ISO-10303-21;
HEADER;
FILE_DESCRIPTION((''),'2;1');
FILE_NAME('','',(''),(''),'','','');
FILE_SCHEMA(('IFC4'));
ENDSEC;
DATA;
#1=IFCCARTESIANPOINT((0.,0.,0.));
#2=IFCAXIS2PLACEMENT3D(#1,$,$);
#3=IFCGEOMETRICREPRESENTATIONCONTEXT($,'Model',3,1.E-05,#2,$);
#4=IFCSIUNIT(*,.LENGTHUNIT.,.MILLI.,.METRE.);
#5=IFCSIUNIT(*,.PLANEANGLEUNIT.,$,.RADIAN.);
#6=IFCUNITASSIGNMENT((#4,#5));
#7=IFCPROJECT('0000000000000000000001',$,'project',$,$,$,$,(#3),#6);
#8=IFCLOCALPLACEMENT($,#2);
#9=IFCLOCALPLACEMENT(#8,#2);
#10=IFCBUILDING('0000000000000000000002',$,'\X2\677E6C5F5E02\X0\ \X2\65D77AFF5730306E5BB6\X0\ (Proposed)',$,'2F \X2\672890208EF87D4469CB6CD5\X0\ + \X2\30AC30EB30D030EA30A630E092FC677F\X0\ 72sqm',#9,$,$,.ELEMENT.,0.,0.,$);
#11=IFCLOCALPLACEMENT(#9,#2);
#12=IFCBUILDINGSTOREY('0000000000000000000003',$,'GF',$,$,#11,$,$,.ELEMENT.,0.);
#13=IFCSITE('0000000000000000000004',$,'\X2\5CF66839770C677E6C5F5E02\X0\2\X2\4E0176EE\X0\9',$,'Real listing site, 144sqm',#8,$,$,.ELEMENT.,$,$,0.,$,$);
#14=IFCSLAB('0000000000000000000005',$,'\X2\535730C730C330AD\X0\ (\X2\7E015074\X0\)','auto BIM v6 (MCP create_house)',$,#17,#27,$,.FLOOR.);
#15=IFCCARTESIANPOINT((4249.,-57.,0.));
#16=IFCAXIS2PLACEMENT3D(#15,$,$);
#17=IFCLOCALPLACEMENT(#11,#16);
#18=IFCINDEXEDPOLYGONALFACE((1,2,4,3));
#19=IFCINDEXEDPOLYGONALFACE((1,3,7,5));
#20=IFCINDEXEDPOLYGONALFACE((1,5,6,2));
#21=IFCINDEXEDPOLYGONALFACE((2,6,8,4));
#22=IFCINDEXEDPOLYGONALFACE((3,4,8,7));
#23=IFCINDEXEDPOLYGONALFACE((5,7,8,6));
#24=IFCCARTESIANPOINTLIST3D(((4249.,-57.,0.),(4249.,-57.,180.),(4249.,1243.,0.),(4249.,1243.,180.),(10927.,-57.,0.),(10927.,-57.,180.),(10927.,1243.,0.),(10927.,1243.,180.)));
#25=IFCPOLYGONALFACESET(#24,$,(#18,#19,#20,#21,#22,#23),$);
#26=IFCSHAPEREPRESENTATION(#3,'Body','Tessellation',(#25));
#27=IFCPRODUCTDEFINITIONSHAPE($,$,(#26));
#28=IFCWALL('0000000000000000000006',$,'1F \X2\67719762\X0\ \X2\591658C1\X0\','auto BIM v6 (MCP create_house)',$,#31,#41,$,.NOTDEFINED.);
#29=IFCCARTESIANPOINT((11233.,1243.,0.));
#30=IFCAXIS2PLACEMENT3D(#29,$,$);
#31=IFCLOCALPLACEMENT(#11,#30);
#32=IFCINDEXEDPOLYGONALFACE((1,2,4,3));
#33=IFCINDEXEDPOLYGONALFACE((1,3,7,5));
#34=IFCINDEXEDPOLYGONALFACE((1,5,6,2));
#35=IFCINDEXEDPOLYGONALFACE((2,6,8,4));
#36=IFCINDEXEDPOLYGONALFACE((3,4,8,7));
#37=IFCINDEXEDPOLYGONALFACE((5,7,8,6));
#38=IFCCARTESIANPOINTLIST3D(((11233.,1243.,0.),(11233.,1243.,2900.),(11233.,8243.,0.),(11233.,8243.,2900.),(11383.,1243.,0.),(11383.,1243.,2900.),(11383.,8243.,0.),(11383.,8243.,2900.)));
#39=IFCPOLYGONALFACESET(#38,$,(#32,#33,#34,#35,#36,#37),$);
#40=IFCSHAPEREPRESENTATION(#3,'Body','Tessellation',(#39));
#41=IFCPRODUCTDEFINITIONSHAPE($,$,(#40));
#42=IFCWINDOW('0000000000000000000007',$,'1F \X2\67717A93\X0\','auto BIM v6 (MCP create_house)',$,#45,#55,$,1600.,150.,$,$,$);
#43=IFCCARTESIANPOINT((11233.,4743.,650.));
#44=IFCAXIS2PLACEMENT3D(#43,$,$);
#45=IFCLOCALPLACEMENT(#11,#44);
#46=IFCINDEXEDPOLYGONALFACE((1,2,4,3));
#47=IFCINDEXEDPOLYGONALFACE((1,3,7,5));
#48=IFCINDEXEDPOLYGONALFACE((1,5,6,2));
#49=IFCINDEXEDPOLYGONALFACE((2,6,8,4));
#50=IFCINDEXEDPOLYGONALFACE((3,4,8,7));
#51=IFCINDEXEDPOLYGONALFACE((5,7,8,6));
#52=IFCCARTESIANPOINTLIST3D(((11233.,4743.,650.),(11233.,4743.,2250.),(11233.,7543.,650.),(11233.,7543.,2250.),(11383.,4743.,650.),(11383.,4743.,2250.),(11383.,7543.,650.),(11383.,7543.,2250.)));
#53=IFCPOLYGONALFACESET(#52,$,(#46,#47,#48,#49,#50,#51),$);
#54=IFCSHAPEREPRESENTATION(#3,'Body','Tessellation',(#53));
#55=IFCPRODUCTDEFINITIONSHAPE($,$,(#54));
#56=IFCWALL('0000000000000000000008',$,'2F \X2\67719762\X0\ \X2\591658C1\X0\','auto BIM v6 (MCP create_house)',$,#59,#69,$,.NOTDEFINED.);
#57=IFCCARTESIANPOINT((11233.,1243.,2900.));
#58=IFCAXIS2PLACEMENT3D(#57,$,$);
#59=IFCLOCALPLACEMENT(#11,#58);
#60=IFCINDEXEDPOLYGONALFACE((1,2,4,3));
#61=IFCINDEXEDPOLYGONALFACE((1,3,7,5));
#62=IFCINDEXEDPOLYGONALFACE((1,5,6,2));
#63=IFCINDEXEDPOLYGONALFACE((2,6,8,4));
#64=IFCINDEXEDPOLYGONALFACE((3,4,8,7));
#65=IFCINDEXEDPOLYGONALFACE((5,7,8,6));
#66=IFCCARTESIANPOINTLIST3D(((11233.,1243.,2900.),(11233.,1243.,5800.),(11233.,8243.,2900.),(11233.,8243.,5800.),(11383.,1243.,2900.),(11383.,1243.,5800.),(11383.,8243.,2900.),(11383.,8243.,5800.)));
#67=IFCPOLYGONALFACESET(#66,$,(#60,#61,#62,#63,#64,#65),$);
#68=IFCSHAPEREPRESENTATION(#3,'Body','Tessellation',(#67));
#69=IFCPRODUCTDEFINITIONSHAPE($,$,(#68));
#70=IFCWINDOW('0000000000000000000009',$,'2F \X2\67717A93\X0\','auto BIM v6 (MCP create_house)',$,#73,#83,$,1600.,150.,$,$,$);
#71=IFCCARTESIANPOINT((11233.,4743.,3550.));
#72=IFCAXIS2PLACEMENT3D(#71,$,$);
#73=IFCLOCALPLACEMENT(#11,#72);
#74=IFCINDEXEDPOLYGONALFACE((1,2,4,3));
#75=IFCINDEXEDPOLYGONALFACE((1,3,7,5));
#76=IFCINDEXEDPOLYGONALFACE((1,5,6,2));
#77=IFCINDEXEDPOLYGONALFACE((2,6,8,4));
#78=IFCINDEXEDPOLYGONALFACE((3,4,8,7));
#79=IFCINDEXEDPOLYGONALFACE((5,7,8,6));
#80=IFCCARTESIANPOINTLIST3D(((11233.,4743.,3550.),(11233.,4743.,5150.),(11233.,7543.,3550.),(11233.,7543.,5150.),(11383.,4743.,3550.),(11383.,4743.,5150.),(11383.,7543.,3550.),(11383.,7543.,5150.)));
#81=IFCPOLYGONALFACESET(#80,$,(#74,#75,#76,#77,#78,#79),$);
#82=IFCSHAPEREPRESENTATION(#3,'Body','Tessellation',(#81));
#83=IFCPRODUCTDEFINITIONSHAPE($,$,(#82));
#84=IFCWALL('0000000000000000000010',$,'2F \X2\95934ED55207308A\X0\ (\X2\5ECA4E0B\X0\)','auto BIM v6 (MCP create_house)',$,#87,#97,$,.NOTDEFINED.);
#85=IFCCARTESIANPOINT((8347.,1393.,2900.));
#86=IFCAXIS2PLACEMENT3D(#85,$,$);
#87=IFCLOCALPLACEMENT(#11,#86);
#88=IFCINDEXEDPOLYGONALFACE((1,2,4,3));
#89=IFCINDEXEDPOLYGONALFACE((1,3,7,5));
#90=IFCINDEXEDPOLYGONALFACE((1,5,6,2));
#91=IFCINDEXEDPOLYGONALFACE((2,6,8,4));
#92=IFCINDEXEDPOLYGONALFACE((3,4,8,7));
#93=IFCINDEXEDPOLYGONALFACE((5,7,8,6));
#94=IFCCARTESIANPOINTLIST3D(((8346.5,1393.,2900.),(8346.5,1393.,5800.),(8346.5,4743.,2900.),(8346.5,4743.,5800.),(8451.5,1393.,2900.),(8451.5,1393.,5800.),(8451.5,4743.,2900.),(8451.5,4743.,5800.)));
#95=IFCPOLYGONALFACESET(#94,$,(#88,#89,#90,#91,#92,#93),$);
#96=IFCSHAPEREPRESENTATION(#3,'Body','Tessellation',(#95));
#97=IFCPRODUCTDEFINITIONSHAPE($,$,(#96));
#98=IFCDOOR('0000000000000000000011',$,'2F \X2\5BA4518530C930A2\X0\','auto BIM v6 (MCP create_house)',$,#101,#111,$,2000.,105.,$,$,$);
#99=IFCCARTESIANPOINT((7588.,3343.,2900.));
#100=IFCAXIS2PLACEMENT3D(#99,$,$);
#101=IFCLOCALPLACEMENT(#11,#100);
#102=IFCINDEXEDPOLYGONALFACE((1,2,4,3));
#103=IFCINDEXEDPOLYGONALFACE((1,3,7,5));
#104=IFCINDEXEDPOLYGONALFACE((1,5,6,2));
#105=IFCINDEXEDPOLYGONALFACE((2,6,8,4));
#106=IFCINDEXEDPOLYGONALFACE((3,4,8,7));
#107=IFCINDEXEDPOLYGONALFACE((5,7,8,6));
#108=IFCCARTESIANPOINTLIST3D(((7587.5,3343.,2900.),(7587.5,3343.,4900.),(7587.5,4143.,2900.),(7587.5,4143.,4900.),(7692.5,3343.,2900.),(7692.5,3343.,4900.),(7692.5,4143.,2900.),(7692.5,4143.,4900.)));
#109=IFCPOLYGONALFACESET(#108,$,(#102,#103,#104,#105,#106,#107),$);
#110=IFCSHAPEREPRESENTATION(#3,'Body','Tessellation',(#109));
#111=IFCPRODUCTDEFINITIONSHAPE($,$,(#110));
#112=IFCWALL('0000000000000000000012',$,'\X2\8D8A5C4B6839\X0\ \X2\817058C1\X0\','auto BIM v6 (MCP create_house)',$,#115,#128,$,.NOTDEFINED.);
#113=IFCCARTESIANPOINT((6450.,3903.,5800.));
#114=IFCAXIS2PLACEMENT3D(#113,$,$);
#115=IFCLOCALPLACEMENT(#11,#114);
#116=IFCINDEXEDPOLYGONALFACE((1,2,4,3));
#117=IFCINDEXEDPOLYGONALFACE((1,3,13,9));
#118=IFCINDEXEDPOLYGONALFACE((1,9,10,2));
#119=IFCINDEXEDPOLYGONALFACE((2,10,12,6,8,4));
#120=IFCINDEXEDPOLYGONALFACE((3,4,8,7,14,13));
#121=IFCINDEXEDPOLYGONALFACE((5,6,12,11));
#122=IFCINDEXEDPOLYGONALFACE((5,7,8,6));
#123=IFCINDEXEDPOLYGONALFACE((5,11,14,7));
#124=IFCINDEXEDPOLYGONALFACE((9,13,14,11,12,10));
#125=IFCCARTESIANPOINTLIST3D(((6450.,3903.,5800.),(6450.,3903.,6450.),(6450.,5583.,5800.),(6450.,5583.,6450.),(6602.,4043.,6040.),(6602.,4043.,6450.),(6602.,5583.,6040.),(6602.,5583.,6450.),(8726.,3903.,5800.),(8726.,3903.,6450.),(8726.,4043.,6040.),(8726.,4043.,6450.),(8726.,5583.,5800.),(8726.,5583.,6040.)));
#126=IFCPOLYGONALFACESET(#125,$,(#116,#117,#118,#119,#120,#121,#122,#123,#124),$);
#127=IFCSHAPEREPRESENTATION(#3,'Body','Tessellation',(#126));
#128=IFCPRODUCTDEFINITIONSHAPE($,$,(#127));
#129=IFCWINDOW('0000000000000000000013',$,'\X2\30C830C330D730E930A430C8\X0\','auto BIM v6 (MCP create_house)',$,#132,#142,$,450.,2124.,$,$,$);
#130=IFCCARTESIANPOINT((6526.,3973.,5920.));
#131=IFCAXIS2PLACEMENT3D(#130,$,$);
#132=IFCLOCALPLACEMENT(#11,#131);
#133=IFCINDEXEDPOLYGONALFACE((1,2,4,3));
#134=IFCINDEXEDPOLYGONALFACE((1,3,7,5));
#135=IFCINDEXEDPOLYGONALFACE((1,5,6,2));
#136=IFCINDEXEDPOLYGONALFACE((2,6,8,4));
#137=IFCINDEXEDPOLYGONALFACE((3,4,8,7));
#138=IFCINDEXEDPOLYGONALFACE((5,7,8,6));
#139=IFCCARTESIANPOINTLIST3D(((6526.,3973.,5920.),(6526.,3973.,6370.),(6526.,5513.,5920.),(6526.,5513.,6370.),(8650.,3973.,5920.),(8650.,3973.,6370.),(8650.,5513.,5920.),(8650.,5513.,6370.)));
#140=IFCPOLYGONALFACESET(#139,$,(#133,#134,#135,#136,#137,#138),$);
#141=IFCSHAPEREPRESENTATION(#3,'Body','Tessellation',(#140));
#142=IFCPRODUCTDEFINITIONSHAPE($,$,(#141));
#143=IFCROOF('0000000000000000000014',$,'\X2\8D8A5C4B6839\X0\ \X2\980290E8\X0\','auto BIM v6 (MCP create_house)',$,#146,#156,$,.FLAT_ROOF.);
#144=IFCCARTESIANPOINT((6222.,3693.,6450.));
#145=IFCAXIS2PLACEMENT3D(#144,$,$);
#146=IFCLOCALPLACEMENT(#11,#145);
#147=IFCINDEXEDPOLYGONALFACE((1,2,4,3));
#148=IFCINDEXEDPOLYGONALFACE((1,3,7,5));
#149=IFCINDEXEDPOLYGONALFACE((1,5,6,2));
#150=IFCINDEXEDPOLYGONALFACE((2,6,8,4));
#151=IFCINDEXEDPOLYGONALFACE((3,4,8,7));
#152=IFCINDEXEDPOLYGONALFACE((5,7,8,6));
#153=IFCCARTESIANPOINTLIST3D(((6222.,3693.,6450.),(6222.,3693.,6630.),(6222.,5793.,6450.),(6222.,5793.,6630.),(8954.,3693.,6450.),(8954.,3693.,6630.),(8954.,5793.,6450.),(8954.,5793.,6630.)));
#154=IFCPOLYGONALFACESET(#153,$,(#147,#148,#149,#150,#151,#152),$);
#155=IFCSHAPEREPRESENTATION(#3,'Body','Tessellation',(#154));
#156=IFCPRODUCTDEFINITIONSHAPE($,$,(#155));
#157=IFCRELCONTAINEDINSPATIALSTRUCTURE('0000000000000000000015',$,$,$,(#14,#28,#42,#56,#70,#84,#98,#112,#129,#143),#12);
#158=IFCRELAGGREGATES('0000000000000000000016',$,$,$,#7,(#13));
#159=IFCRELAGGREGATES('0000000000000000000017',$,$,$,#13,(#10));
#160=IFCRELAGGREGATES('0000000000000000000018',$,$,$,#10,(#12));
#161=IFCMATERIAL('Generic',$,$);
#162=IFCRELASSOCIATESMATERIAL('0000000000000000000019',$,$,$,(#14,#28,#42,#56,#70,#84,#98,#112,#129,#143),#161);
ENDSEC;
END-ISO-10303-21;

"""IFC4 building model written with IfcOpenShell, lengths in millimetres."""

from ifc_helpers import new_model, si_unit, frame, frame_2d, origin, place, context, project, spatial, rectangle, extrude, material, element, fill, save


model = new_model("IFC4")

# Units and contexts
model_context = context("Model", 3, precision=1e-05, world=origin())
ifc_project = project(units=[si_unit("LENGTHUNIT", "METRE", prefix="MILLI"), si_unit("PLANEANGLEUNIT", "RADIAN")], contexts=[model_context])

# Site, building, storey
site_placement = place(None, origin())
site = spatial("IfcSite", under=ifc_project, at=site_placement, Name="島根県松江市2丁目9", ObjectType="Real listing site, 144sqm", CompositionType="ELEMENT", RefElevation=0.0)
building_placement = place(site_placement, origin())
building = spatial("IfcBuilding", under=site, at=building_placement, Name="松江市 旗竿地の家 (Proposed)", ObjectType="2F 木造軸組構法 + ガルバリウム鋼板 72sqm", CompositionType="ELEMENT", ElevationOfRefHeight=0.0, ElevationOfTerrain=0.0)
storey_placement = place(building_placement, origin())
storey = spatial("IfcBuildingStorey", under=building, at=storey_placement, Name="GF", CompositionType="ELEMENT", Elevation=0.0)

# Slab
ifc_material = material(Name="Generic")
slab_placement = place(storey_placement, frame((4249.0, -57.0, 0.0)))
element("IfcSlab", 1, at=slab_placement, inside=storey, material=ifc_material, Name="南デッキ (縁側)", Description="auto BIM v6 (MCP create_house)", PredefinedType="FLOOR", context=model_context, shape_type="SweptSolid", body=[
    extrude(rectangle(XDim=6678.0, YDim=1300.0, at=frame_2d((3339.0, 650.0))), frame((4249.0, -57.0, 0.0)), (0.0, 0.0, 1.0), 180.0),
])

# Wall, opening, window
wall_1_placement = place(storey_placement, frame((11233.0, 1243.0, 0.0)))
wall_1 = element("IfcWall", 2, at=wall_1_placement, inside=storey, material=ifc_material, Name="1F 東面 外壁", Description="auto BIM v6 (MCP create_house)", PredefinedType="NOTDEFINED", context=model_context, shape_type="SweptSolid", body=[
    extrude(rectangle(XDim=150.0, YDim=7000.0, at=frame_2d((75.0, 3500.0))), frame((11233.0, 1243.0, 0.0)), (0.0, 0.0, 1.0), 2900.0),
])
opening_1_placement = place(storey_placement, frame((11233.0, 4743.0, 650.0)))
opening_1 = element("IfcOpeningElement", 3, at=opening_1_placement, cuts=wall_1, PredefinedType="NOTDEFINED", context=model_context, shape_type="SweptSolid", body=[
    extrude(rectangle(XDim=150.0, YDim=2800.0, at=frame_2d((75.0, 1400.0))), frame((11233.0, 4743.0, 650.0)), (0.0, 0.0, 1.0), 1600.0),
])
window_1_placement = place(storey_placement, frame((11233.0, 4743.0, 650.0)))
window_1 = element("IfcWindow", 4, at=window_1_placement, inside=storey, material=ifc_material, Name="1F 東窓", Description="auto BIM v6 (MCP create_house)", OverallHeight=1600.0, OverallWidth=150.0, context=model_context, shape_type="SweptSolid", body=[
    extrude(rectangle(XDim=150.0, YDim=2800.0, at=frame_2d((75.0, 1400.0))), frame((11233.0, 4743.0, 650.0)), (0.0, 0.0, 1.0), 1600.0),
])
fill(opening_1, window_1)

# Wall, opening, window
wall_2_placement = place(storey_placement, frame((11233.0, 1243.0, 2900.0)))
wall_2 = element("IfcWall", 5, at=wall_2_placement, inside=storey, material=ifc_material, Name="2F 東面 外壁", Description="auto BIM v6 (MCP create_house)", PredefinedType="NOTDEFINED", context=model_context, shape_type="SweptSolid", body=[
    extrude(rectangle(XDim=150.0, YDim=7000.0, at=frame_2d((75.0, 3500.0))), frame((11233.0, 1243.0, 2900.0)), (0.0, 0.0, 1.0), 2900.0),
])
opening_2_placement = place(storey_placement, frame((11233.0, 4743.0, 3550.0)))
opening_2 = element("IfcOpeningElement", 6, at=opening_2_placement, cuts=wall_2, PredefinedType="NOTDEFINED", context=model_context, shape_type="SweptSolid", body=[
    extrude(rectangle(XDim=150.0, YDim=2800.0, at=frame_2d((75.0, 1400.0))), frame((11233.0, 4743.0, 3550.0)), (0.0, 0.0, 1.0), 1600.0),
])
window_2_placement = place(storey_placement, frame((11233.0, 4743.0, 3550.0)))
window_2 = element("IfcWindow", 7, at=window_2_placement, inside=storey, material=ifc_material, Name="2F 東窓", Description="auto BIM v6 (MCP create_house)", OverallHeight=1600.0, OverallWidth=150.0, context=model_context, shape_type="SweptSolid", body=[
    extrude(rectangle(XDim=150.0, YDim=2800.0, at=frame_2d((75.0, 1400.0))), frame((11233.0, 4743.0, 3550.0)), (0.0, 0.0, 1.0), 1600.0),
])
fill(opening_2, window_2)

# Wall
wall_3_placement = place(storey_placement, frame((8347.0, 1393.0, 2900.0)))
element("IfcWall", 8, at=wall_3_placement, inside=storey, material=ifc_material, Name="2F 間仕切り (廊下)", Description="auto BIM v6 (MCP create_house)", PredefinedType="NOTDEFINED", context=model_context, shape_type="SweptSolid", body=[
    extrude(rectangle(XDim=105.0, YDim=3350.0, at=frame_2d((52.0, 1675.0))), frame((8347.0, 1393.0, 2900.0)), (0.0, 0.0, 1.0), 2900.0),
])

# Door
door_placement = place(storey_placement, frame((7588.0, 3343.0, 2900.0)))
element("IfcDoor", 9, at=door_placement, inside=storey, material=ifc_material, Name="2F 室内ドア", Description="auto BIM v6 (MCP create_house)", OverallHeight=2000.0, OverallWidth=105.0, context=model_context, shape_type="SweptSolid", body=[
    extrude(rectangle(XDim=105.0, YDim=800.0, at=frame_2d((52.0, 400.0))), frame((7588.0, 3343.0, 2900.0)), (0.0, 0.0, 1.0), 2000.0),
])

# Wall, opening, window
wall_4_placement = place(storey_placement, frame((6450.0, 3903.0, 5800.0)))
wall_4 = element("IfcWall", 10, at=wall_4_placement, inside=storey, material=ifc_material, Name="越屋根 腰壁", Description="auto BIM v6 (MCP create_house)", PredefinedType="NOTDEFINED", context=model_context, shape_type="SweptSolid", body=[
    extrude(rectangle(XDim=2276.0, YDim=1680.0, at=frame_2d((1138.0, 840.0))), frame((6450.0, 3903.0, 5800.0)), (0.0, 0.0, 1.0), 650.0),
])
opening_3_placement = place(storey_placement, frame((6526.0, 3973.0, 5920.0)))
opening_3 = element("IfcOpeningElement", 11, at=opening_3_placement, cuts=wall_4, PredefinedType="NOTDEFINED", context=model_context, shape_type="SweptSolid", body=[
    extrude(rectangle(XDim=2124.0, YDim=1540.0, at=frame_2d((1062.0, 770.0))), frame((6526.0, 3973.0, 5920.0)), (0.0, 0.0, 1.0), 450.0),
])
window_3_placement = place(storey_placement, frame((6526.0, 3973.0, 5920.0)))
window_3 = element("IfcWindow", 12, at=window_3_placement, inside=storey, material=ifc_material, Name="トップライト", Description="auto BIM v6 (MCP create_house)", OverallHeight=450.0, OverallWidth=2124.0, context=model_context, shape_type="SweptSolid", body=[
    extrude(rectangle(XDim=2124.0, YDim=1540.0, at=frame_2d((1062.0, 770.0))), frame((6526.0, 3973.0, 5920.0)), (0.0, 0.0, 1.0), 450.0),
])
fill(opening_3, window_3)

# Roof
roof_placement = place(storey_placement, frame((6222.0, 3693.0, 6450.0)))
element("IfcRoof", 13, at=roof_placement, inside=storey, material=ifc_material, Name="越屋根 頂部", Description="auto BIM v6 (MCP create_house)", PredefinedType="FLAT_ROOF", context=model_context, shape_type="SweptSolid", body=[
    extrude(rectangle(XDim=2732.0, YDim=2100.0, at=frame_2d((1366.0, 1050.0))), frame((6222.0, 3693.0, 6450.0)), (0.0, 0.0, 1.0), 180.0),
])

save(model, "model.ifc")
